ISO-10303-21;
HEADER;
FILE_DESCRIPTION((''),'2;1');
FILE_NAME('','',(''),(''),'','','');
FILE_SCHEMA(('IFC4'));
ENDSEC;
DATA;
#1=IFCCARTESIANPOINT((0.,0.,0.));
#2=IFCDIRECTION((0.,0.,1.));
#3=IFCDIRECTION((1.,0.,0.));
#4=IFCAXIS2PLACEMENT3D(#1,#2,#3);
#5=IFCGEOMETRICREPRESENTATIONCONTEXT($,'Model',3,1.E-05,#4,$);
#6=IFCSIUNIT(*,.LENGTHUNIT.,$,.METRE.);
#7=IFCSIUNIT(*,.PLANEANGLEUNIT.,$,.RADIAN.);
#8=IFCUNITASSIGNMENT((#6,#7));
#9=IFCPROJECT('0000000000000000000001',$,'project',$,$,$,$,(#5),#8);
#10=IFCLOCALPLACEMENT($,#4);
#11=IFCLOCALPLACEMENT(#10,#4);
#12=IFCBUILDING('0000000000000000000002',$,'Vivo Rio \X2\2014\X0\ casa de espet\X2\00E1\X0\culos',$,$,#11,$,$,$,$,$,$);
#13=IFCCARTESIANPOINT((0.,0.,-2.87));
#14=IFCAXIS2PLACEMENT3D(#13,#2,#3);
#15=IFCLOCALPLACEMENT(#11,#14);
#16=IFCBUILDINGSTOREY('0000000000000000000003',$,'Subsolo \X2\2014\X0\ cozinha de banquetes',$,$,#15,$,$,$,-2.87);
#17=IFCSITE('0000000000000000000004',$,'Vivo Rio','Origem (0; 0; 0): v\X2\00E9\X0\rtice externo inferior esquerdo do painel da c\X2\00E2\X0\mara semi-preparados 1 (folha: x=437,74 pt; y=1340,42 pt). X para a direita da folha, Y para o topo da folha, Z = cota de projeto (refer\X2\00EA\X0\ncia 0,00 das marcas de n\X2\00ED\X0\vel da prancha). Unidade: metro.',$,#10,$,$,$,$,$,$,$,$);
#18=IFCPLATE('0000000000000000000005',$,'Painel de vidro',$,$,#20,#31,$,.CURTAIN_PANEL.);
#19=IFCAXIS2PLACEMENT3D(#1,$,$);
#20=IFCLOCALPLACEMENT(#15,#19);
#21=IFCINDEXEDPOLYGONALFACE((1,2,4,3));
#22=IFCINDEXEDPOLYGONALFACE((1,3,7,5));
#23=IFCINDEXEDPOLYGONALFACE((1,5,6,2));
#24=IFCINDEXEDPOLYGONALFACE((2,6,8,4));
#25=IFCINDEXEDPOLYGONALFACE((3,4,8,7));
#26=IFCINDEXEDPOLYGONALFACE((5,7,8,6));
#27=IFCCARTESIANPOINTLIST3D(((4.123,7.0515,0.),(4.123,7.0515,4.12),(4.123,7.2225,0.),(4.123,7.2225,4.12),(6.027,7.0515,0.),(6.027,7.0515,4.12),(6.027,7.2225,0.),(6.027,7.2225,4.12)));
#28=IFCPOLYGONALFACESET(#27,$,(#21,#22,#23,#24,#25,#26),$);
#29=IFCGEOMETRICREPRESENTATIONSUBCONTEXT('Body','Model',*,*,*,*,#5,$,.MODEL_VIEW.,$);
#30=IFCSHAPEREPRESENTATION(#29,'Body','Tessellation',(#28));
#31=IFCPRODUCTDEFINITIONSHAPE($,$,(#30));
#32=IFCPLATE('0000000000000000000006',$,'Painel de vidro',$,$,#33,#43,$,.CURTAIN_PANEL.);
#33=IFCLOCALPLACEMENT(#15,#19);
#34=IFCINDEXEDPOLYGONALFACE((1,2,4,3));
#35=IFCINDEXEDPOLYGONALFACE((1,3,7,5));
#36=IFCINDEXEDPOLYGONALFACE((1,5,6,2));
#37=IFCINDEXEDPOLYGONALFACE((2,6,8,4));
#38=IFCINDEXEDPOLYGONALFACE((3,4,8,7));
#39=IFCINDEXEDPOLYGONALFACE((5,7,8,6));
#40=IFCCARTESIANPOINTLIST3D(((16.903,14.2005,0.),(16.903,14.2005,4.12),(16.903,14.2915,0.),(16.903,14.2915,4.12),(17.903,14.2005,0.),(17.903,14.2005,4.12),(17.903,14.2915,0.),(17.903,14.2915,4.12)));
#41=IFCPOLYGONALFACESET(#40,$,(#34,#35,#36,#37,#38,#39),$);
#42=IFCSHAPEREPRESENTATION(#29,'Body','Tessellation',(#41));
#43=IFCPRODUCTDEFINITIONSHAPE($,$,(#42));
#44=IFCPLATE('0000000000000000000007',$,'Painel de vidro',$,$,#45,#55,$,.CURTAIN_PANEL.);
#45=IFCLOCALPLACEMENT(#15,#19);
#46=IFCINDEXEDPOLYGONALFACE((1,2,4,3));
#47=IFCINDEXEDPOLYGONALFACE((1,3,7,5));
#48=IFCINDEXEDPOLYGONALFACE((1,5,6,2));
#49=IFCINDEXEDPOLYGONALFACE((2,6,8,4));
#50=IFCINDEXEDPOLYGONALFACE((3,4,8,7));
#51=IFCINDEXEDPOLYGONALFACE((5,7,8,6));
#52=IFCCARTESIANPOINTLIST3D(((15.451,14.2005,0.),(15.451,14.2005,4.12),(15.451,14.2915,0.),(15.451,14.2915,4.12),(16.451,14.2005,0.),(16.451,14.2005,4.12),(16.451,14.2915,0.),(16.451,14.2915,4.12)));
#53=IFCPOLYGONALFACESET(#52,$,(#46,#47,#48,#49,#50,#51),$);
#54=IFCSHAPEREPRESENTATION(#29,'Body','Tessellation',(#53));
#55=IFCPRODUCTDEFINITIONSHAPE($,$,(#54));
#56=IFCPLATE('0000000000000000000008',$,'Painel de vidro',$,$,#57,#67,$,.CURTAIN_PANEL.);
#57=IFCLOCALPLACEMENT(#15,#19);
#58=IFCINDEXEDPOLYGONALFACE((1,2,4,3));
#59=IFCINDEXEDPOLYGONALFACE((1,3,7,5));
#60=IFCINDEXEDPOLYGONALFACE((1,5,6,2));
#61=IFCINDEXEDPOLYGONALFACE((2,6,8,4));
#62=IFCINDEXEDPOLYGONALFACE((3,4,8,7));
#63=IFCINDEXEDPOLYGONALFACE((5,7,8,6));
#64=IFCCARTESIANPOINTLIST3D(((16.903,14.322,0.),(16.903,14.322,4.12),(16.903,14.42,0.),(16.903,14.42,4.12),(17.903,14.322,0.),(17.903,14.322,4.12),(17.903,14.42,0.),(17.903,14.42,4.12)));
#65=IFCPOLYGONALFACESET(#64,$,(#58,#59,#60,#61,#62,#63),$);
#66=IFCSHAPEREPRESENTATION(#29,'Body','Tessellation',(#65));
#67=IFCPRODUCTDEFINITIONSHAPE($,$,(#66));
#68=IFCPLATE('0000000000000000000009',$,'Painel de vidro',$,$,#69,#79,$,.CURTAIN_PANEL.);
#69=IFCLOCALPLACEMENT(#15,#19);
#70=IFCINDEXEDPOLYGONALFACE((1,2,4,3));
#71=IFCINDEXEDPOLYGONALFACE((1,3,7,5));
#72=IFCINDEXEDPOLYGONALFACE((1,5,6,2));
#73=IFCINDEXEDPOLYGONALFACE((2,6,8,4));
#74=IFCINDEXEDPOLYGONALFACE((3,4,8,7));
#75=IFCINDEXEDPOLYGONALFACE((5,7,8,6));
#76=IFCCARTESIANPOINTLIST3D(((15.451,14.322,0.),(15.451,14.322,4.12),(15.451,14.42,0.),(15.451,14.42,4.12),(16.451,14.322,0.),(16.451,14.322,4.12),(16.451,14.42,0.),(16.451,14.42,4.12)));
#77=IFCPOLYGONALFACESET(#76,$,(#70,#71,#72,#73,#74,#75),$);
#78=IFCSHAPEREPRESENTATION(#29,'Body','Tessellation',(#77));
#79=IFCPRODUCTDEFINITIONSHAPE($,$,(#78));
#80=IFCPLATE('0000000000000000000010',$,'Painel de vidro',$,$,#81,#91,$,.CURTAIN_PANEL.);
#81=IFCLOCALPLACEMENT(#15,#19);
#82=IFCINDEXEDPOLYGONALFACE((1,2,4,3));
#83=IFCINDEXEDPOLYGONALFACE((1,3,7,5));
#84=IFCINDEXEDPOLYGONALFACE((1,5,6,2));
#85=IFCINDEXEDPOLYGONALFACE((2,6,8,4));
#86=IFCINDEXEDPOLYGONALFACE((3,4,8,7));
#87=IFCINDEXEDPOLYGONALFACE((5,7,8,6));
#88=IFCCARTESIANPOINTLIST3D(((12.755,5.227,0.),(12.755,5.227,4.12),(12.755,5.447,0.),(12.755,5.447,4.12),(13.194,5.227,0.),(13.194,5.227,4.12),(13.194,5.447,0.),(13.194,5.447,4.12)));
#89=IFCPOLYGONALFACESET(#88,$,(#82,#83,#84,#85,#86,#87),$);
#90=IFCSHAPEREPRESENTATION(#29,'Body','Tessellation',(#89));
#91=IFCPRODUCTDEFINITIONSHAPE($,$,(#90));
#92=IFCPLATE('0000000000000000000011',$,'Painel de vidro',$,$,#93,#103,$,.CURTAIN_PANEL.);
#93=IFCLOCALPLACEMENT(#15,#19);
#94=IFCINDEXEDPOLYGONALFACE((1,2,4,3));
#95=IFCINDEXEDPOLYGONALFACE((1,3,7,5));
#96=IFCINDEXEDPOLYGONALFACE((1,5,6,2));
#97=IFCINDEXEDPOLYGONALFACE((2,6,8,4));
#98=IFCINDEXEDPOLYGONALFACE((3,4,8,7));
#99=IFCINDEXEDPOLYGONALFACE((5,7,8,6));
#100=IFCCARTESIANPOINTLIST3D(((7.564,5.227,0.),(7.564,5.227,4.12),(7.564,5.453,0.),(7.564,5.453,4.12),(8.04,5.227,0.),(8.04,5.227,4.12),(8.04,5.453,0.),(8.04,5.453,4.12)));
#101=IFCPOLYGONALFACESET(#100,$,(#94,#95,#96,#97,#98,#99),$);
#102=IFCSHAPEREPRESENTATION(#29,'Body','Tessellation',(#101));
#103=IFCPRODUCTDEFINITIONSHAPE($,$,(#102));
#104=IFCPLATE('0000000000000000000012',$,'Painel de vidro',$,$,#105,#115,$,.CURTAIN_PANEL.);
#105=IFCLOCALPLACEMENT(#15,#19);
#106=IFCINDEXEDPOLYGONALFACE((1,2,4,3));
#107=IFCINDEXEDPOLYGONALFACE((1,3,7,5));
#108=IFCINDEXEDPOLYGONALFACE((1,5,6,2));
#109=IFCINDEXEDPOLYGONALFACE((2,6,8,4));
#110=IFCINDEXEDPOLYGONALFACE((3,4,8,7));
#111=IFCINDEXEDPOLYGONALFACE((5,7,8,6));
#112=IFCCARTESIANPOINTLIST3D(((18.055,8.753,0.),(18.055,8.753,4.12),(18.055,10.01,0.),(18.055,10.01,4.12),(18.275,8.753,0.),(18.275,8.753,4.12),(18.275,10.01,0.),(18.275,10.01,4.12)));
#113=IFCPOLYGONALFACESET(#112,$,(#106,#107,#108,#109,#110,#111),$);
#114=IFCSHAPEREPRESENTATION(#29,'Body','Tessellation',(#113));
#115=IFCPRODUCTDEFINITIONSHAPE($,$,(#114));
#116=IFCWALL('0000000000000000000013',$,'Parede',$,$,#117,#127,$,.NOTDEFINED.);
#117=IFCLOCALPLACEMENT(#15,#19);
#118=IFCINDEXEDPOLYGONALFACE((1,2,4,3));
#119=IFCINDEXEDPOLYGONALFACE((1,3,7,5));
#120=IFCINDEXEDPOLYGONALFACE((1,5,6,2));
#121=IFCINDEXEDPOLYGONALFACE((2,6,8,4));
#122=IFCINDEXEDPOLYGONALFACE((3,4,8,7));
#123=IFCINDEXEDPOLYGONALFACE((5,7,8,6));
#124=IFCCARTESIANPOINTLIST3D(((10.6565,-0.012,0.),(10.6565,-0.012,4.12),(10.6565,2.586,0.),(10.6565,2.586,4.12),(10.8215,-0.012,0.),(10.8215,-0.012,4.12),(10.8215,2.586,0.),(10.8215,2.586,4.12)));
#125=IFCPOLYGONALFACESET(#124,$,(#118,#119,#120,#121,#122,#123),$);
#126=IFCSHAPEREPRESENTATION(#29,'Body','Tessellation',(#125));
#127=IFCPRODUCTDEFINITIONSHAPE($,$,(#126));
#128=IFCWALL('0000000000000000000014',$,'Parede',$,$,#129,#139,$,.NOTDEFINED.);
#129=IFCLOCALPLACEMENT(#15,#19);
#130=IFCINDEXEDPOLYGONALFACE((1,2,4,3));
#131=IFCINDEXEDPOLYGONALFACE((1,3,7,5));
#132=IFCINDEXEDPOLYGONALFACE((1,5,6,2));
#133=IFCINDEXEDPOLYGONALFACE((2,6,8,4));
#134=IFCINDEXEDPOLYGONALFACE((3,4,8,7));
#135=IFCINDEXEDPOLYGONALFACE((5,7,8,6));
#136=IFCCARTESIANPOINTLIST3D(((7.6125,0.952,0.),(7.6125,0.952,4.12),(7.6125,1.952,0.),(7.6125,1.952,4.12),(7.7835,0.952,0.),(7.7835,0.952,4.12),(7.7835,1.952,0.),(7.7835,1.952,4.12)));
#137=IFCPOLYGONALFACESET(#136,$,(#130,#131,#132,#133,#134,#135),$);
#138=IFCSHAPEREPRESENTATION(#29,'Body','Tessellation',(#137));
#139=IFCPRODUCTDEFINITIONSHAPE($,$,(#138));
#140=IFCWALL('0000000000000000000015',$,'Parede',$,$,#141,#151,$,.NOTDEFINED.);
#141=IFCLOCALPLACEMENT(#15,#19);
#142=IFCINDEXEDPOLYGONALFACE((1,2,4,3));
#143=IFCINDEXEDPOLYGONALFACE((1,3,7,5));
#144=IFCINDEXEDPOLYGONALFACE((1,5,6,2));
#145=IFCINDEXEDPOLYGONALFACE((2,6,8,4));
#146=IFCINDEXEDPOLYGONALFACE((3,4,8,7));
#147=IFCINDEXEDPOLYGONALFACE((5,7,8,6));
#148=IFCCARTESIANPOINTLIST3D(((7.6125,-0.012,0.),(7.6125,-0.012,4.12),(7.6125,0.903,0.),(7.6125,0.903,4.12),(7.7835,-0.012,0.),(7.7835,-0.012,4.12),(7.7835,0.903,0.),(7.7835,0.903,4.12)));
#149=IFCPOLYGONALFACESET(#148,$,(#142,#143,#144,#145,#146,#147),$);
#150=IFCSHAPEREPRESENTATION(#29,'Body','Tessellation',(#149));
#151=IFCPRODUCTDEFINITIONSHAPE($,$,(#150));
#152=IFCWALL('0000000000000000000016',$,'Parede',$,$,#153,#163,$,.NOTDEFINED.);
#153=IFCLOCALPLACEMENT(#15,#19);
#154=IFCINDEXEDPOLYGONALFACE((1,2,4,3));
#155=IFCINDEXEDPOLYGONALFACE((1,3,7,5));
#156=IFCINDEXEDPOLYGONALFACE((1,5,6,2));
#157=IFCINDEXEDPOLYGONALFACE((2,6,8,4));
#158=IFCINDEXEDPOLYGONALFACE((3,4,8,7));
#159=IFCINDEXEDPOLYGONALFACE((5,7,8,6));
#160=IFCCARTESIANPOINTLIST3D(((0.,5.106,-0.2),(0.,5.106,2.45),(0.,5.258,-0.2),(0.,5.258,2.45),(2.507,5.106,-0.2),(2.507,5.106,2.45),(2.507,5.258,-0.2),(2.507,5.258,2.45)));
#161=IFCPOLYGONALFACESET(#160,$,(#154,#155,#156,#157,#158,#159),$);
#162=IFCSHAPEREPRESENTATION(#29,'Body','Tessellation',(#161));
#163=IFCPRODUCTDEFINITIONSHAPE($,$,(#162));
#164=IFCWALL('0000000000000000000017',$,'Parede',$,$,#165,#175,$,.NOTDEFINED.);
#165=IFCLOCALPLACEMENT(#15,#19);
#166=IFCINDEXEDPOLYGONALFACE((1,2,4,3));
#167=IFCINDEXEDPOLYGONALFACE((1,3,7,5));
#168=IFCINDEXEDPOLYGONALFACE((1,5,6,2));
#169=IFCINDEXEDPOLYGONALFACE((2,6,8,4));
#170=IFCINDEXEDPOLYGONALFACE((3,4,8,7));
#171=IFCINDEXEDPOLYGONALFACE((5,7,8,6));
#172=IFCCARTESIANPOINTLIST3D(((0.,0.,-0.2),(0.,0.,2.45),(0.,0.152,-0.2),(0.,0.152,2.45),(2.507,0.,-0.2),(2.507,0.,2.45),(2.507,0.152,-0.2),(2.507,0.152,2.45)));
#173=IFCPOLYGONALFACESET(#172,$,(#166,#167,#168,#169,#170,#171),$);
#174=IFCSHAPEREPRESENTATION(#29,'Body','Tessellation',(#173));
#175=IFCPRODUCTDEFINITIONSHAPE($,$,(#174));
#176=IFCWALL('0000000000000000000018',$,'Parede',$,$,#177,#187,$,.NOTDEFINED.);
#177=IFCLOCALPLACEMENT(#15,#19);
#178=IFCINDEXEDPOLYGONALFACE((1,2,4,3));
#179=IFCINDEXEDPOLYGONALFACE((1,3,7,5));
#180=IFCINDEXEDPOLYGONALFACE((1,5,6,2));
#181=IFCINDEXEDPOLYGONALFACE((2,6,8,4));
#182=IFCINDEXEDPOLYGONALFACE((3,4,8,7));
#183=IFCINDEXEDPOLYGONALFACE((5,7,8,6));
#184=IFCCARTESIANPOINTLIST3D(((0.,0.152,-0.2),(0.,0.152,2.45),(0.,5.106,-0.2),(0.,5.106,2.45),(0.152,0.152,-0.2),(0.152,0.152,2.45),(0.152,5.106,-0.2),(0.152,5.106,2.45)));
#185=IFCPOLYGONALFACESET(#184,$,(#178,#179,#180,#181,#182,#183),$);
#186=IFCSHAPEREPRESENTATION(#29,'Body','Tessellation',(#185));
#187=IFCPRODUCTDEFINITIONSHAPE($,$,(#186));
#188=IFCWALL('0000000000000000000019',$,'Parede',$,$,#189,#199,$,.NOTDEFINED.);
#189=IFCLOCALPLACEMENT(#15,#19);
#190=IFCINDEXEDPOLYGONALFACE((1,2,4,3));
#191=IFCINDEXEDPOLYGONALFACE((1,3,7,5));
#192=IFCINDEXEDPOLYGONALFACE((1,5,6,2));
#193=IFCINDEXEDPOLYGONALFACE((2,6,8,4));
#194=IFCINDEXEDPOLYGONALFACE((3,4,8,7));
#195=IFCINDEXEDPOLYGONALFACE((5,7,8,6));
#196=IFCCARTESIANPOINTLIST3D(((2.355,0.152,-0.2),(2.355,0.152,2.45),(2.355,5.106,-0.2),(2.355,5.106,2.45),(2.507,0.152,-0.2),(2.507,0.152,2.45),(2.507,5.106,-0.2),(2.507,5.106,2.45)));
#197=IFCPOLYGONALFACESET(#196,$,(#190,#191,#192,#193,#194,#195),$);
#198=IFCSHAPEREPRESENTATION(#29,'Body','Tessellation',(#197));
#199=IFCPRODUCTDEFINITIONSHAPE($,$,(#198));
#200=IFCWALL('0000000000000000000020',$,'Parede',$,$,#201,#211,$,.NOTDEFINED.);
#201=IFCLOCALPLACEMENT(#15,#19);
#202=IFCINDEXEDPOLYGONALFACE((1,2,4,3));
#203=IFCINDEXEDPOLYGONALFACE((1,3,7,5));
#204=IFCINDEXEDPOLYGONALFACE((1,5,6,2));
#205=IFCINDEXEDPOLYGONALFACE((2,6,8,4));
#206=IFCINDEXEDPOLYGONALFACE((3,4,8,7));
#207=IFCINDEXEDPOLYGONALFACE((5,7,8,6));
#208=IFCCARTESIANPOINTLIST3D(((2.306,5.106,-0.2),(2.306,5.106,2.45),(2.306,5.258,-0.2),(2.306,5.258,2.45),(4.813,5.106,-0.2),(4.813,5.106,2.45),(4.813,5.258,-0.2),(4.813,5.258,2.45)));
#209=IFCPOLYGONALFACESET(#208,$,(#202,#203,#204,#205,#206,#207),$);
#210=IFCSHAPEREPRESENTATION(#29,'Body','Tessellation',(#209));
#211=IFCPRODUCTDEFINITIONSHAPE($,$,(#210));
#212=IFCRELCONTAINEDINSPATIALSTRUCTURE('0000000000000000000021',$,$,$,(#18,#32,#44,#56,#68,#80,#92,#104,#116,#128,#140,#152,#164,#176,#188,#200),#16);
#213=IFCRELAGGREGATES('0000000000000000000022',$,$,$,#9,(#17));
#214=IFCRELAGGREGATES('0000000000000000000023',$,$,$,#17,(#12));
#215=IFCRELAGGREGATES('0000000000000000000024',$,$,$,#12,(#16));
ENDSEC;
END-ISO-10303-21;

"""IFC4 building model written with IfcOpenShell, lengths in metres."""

from ifc_helpers import new_model, si_unit, frame, origin_with_axes, origin_2d, place, context, subcontext, project, spatial, rectangle, extrude, element, save


model = new_model("IFC4")

# Units and contexts
model_context = context("Model", 3, precision=1e-05, world=origin_with_axes())
body_context = subcontext(model_context, "Body", "Model", "MODEL_VIEW")
ifc_project = project(units=[si_unit("LENGTHUNIT", "METRE"), si_unit("PLANEANGLEUNIT", "RADIAN")], contexts=[model_context])

# Site, building, storey
site_placement = place(None, origin_with_axes())
site = spatial("IfcSite", under=ifc_project, at=site_placement, Name="Vivo Rio", Description="Origem (0; 0; 0): vértice externo inferior esquerdo do painel da câmara semi-preparados 1 (folha: x=437,74 pt; y=1340,42 pt). X para a direita da folha, Y para o topo da folha, Z = cota de projeto (referência 0,00 das marcas de nível da prancha). Unidade: metro.")
building_placement = place(site_placement, origin_with_axes())
building = spatial("IfcBuilding", under=site, at=building_placement, Name="Vivo Rio — casa de espetáculos")
storey_placement = place(building_placement, frame((0.0, 0.0, -2.87), z_axis=(0.0, 0.0, 1.0), x_axis=(1.0, 0.0, 0.0)))
storey = spatial("IfcBuildingStorey", under=building, at=storey_placement, Name="Subsolo — cozinha de banquetes", Elevation=-2.87)

# Plates
plate_1_placement = place(storey_placement, origin_with_axes())
element("IfcPlate", 1, at=plate_1_placement, inside=storey, Name="Painel de vidro", PredefinedType="CURTAIN_PANEL", context=body_context, shape_type="SweptSolid", body=[
    extrude(rectangle(XDim=1.904, YDim=0.171, at=origin_2d()), frame((5.075, 7.137, 0.0), z_axis=(0.0, 0.0, 1.0), x_axis=(1.0, 0.0, 0.0)), (0.0, 0.0, 1.0), 4.12),
])
plate_2_placement = place(storey_placement, origin_with_axes())
element("IfcPlate", 2, at=plate_2_placement, inside=storey, Name="Painel de vidro", PredefinedType="CURTAIN_PANEL", context=body_context, shape_type="SweptSolid", body=[
    extrude(rectangle(XDim=1.0, YDim=0.091, at=origin_2d()), frame((17.403, 14.246, 0.0), z_axis=(0.0, 0.0, 1.0), x_axis=(1.0, 0.0, 0.0)), (0.0, 0.0, 1.0), 4.12),
])
plate_3_placement = place(storey_placement, origin_with_axes())
element("IfcPlate", 3, at=plate_3_placement, inside=storey, Name="Painel de vidro", PredefinedType="CURTAIN_PANEL", context=body_context, shape_type="SweptSolid", body=[
    extrude(rectangle(XDim=1.0, YDim=0.091, at=origin_2d()), frame((15.951, 14.246, 0.0), z_axis=(0.0, 0.0, 1.0), x_axis=(1.0, 0.0, 0.0)), (0.0, 0.0, 1.0), 4.12),
])
plate_4_placement = place(storey_placement, origin_with_axes())
element("IfcPlate", 4, at=plate_4_placement, inside=storey, Name="Painel de vidro", PredefinedType="CURTAIN_PANEL", context=body_context, shape_type="SweptSolid", body=[
    extrude(rectangle(XDim=1.0, YDim=0.098, at=origin_2d()), frame((17.403, 14.371, 0.0), z_axis=(0.0, 0.0, 1.0), x_axis=(1.0, 0.0, 0.0)), (0.0, 0.0, 1.0), 4.12),
])
plate_5_placement = place(storey_placement, origin_with_axes())
element("IfcPlate", 5, at=plate_5_placement, inside=storey, Name="Painel de vidro", PredefinedType="CURTAIN_PANEL", context=body_context, shape_type="SweptSolid", body=[
    extrude(rectangle(XDim=1.0, YDim=0.098, at=origin_2d()), frame((15.951, 14.371, 0.0), z_axis=(0.0, 0.0, 1.0), x_axis=(1.0, 0.0, 0.0)), (0.0, 0.0, 1.0), 4.12),
])
plate_6_placement = place(storey_placement, origin_with_axes())
element("IfcPlate", 6, at=plate_6_placement, inside=storey, Name="Painel de vidro", PredefinedType="CURTAIN_PANEL", context=body_context, shape_type="SweptSolid", body=[
    extrude(rectangle(XDim=0.439, YDim=0.22, at=origin_2d()), frame((12.9745, 5.337, 0.0), z_axis=(0.0, 0.0, 1.0), x_axis=(1.0, 0.0, 0.0)), (0.0, 0.0, 1.0), 4.12),
])
plate_7_placement = place(storey_placement, origin_with_axes())
element("IfcPlate", 7, at=plate_7_placement, inside=storey, Name="Painel de vidro", PredefinedType="CURTAIN_PANEL", context=body_context, shape_type="SweptSolid", body=[
    extrude(rectangle(XDim=0.476, YDim=0.226, at=origin_2d()), frame((7.802, 5.34, 0.0), z_axis=(0.0, 0.0, 1.0), x_axis=(1.0, 0.0, 0.0)), (0.0, 0.0, 1.0), 4.12),
])
plate_8_placement = place(storey_placement, origin_with_axes())
element("IfcPlate", 8, at=plate_8_placement, inside=storey, Name="Painel de vidro", PredefinedType="CURTAIN_PANEL", context=body_context, shape_type="SweptSolid", body=[
    extrude(rectangle(XDim=1.257, YDim=0.22, at=origin_2d()), frame((18.165, 9.3815, 0.0), z_axis=(0.0, 0.0, 1.0), x_axis=(0.0, -1.0, 0.0)), (0.0, 0.0, 1.0), 4.12),
])

# Walls
wall_1_placement = place(storey_placement, origin_with_axes())
element("IfcWall", 9, at=wall_1_placement, inside=storey, Name="Parede", PredefinedType="NOTDEFINED", context=body_context, shape_type="SweptSolid", body=[
    extrude(rectangle(XDim=2.598, YDim=0.165, at=origin_2d()), frame((10.739, 1.287, 0.0), z_axis=(0.0, 0.0, 1.0), x_axis=(0.0, -1.0, 0.0)), (0.0, 0.0, 1.0), 4.12),
])
wall_2_placement = place(storey_placement, origin_with_axes())
element("IfcWall", 10, at=wall_2_placement, inside=storey, Name="Parede", PredefinedType="NOTDEFINED", context=body_context, shape_type="SweptSolid", body=[
    extrude(rectangle(XDim=1.0, YDim=0.171, at=origin_2d()), frame((7.698, 1.452, 0.0), z_axis=(0.0, 0.0, 1.0), x_axis=(0.0, -1.0, 0.0)), (0.0, 0.0, 1.0), 4.12),
])
wall_3_placement = place(storey_placement, origin_with_axes())
element("IfcWall", 11, at=wall_3_placement, inside=storey, Name="Parede", PredefinedType="NOTDEFINED", context=body_context, shape_type="SweptSolid", body=[
    extrude(rectangle(XDim=0.915, YDim=0.171, at=origin_2d()), frame((7.698, 0.4455, 0.0), z_axis=(0.0, 0.0, 1.0), x_axis=(0.0, -1.0, 0.0)), (0.0, 0.0, 1.0), 4.12),
])
wall_4_placement = place(storey_placement, origin_with_axes())
element("IfcWall", 12, at=wall_4_placement, inside=storey, Name="Parede", PredefinedType="NOTDEFINED", context=body_context, shape_type="SweptSolid", body=[
    extrude(rectangle(XDim=2.507, YDim=0.152, at=origin_2d()), frame((1.2535, 5.182, -0.2), z_axis=(0.0, 0.0, 1.0), x_axis=(1.0, 0.0, 0.0)), (0.0, 0.0, 1.0), 2.65),
])
wall_5_placement = place(storey_placement, origin_with_axes())
element("IfcWall", 13, at=wall_5_placement, inside=storey, Name="Parede", PredefinedType="NOTDEFINED", context=body_context, shape_type="SweptSolid", body=[
    extrude(rectangle(XDim=2.507, YDim=0.152, at=origin_2d()), frame((1.2535, 0.076, -0.2), z_axis=(0.0, 0.0, 1.0), x_axis=(1.0, 0.0, 0.0)), (0.0, 0.0, 1.0), 2.65),
])
wall_6_placement = place(storey_placement, origin_with_axes())
element("IfcWall", 14, at=wall_6_placement, inside=storey, Name="Parede", PredefinedType="NOTDEFINED", context=body_context, shape_type="SweptSolid", body=[
    extrude(rectangle(XDim=4.954, YDim=0.152, at=origin_2d()), frame((0.076, 2.629, -0.2), z_axis=(0.0, 0.0, 1.0), x_axis=(0.0, -1.0, 0.0)), (0.0, 0.0, 1.0), 2.65),
])
wall_7_placement = place(storey_placement, origin_with_axes())
element("IfcWall", 15, at=wall_7_placement, inside=storey, Name="Parede", PredefinedType="NOTDEFINED", context=body_context, shape_type="SweptSolid", body=[
    extrude(rectangle(XDim=4.954, YDim=0.152, at=origin_2d()), frame((2.431, 2.629, -0.2), z_axis=(0.0, 0.0, 1.0), x_axis=(0.0, -1.0, 0.0)), (0.0, 0.0, 1.0), 2.65),
])
wall_8_placement = place(storey_placement, origin_with_axes())
element("IfcWall", 16, at=wall_8_placement, inside=storey, Name="Parede", PredefinedType="NOTDEFINED", context=body_context, shape_type="SweptSolid", body=[
    extrude(rectangle(XDim=2.507, YDim=0.152, at=origin_2d()), frame((3.5595, 5.182, -0.2), z_axis=(0.0, 0.0, 1.0), x_axis=(1.0, 0.0, 0.0)), (0.0, 0.0, 1.0), 2.65),
])

save(model, "model.ifc")
